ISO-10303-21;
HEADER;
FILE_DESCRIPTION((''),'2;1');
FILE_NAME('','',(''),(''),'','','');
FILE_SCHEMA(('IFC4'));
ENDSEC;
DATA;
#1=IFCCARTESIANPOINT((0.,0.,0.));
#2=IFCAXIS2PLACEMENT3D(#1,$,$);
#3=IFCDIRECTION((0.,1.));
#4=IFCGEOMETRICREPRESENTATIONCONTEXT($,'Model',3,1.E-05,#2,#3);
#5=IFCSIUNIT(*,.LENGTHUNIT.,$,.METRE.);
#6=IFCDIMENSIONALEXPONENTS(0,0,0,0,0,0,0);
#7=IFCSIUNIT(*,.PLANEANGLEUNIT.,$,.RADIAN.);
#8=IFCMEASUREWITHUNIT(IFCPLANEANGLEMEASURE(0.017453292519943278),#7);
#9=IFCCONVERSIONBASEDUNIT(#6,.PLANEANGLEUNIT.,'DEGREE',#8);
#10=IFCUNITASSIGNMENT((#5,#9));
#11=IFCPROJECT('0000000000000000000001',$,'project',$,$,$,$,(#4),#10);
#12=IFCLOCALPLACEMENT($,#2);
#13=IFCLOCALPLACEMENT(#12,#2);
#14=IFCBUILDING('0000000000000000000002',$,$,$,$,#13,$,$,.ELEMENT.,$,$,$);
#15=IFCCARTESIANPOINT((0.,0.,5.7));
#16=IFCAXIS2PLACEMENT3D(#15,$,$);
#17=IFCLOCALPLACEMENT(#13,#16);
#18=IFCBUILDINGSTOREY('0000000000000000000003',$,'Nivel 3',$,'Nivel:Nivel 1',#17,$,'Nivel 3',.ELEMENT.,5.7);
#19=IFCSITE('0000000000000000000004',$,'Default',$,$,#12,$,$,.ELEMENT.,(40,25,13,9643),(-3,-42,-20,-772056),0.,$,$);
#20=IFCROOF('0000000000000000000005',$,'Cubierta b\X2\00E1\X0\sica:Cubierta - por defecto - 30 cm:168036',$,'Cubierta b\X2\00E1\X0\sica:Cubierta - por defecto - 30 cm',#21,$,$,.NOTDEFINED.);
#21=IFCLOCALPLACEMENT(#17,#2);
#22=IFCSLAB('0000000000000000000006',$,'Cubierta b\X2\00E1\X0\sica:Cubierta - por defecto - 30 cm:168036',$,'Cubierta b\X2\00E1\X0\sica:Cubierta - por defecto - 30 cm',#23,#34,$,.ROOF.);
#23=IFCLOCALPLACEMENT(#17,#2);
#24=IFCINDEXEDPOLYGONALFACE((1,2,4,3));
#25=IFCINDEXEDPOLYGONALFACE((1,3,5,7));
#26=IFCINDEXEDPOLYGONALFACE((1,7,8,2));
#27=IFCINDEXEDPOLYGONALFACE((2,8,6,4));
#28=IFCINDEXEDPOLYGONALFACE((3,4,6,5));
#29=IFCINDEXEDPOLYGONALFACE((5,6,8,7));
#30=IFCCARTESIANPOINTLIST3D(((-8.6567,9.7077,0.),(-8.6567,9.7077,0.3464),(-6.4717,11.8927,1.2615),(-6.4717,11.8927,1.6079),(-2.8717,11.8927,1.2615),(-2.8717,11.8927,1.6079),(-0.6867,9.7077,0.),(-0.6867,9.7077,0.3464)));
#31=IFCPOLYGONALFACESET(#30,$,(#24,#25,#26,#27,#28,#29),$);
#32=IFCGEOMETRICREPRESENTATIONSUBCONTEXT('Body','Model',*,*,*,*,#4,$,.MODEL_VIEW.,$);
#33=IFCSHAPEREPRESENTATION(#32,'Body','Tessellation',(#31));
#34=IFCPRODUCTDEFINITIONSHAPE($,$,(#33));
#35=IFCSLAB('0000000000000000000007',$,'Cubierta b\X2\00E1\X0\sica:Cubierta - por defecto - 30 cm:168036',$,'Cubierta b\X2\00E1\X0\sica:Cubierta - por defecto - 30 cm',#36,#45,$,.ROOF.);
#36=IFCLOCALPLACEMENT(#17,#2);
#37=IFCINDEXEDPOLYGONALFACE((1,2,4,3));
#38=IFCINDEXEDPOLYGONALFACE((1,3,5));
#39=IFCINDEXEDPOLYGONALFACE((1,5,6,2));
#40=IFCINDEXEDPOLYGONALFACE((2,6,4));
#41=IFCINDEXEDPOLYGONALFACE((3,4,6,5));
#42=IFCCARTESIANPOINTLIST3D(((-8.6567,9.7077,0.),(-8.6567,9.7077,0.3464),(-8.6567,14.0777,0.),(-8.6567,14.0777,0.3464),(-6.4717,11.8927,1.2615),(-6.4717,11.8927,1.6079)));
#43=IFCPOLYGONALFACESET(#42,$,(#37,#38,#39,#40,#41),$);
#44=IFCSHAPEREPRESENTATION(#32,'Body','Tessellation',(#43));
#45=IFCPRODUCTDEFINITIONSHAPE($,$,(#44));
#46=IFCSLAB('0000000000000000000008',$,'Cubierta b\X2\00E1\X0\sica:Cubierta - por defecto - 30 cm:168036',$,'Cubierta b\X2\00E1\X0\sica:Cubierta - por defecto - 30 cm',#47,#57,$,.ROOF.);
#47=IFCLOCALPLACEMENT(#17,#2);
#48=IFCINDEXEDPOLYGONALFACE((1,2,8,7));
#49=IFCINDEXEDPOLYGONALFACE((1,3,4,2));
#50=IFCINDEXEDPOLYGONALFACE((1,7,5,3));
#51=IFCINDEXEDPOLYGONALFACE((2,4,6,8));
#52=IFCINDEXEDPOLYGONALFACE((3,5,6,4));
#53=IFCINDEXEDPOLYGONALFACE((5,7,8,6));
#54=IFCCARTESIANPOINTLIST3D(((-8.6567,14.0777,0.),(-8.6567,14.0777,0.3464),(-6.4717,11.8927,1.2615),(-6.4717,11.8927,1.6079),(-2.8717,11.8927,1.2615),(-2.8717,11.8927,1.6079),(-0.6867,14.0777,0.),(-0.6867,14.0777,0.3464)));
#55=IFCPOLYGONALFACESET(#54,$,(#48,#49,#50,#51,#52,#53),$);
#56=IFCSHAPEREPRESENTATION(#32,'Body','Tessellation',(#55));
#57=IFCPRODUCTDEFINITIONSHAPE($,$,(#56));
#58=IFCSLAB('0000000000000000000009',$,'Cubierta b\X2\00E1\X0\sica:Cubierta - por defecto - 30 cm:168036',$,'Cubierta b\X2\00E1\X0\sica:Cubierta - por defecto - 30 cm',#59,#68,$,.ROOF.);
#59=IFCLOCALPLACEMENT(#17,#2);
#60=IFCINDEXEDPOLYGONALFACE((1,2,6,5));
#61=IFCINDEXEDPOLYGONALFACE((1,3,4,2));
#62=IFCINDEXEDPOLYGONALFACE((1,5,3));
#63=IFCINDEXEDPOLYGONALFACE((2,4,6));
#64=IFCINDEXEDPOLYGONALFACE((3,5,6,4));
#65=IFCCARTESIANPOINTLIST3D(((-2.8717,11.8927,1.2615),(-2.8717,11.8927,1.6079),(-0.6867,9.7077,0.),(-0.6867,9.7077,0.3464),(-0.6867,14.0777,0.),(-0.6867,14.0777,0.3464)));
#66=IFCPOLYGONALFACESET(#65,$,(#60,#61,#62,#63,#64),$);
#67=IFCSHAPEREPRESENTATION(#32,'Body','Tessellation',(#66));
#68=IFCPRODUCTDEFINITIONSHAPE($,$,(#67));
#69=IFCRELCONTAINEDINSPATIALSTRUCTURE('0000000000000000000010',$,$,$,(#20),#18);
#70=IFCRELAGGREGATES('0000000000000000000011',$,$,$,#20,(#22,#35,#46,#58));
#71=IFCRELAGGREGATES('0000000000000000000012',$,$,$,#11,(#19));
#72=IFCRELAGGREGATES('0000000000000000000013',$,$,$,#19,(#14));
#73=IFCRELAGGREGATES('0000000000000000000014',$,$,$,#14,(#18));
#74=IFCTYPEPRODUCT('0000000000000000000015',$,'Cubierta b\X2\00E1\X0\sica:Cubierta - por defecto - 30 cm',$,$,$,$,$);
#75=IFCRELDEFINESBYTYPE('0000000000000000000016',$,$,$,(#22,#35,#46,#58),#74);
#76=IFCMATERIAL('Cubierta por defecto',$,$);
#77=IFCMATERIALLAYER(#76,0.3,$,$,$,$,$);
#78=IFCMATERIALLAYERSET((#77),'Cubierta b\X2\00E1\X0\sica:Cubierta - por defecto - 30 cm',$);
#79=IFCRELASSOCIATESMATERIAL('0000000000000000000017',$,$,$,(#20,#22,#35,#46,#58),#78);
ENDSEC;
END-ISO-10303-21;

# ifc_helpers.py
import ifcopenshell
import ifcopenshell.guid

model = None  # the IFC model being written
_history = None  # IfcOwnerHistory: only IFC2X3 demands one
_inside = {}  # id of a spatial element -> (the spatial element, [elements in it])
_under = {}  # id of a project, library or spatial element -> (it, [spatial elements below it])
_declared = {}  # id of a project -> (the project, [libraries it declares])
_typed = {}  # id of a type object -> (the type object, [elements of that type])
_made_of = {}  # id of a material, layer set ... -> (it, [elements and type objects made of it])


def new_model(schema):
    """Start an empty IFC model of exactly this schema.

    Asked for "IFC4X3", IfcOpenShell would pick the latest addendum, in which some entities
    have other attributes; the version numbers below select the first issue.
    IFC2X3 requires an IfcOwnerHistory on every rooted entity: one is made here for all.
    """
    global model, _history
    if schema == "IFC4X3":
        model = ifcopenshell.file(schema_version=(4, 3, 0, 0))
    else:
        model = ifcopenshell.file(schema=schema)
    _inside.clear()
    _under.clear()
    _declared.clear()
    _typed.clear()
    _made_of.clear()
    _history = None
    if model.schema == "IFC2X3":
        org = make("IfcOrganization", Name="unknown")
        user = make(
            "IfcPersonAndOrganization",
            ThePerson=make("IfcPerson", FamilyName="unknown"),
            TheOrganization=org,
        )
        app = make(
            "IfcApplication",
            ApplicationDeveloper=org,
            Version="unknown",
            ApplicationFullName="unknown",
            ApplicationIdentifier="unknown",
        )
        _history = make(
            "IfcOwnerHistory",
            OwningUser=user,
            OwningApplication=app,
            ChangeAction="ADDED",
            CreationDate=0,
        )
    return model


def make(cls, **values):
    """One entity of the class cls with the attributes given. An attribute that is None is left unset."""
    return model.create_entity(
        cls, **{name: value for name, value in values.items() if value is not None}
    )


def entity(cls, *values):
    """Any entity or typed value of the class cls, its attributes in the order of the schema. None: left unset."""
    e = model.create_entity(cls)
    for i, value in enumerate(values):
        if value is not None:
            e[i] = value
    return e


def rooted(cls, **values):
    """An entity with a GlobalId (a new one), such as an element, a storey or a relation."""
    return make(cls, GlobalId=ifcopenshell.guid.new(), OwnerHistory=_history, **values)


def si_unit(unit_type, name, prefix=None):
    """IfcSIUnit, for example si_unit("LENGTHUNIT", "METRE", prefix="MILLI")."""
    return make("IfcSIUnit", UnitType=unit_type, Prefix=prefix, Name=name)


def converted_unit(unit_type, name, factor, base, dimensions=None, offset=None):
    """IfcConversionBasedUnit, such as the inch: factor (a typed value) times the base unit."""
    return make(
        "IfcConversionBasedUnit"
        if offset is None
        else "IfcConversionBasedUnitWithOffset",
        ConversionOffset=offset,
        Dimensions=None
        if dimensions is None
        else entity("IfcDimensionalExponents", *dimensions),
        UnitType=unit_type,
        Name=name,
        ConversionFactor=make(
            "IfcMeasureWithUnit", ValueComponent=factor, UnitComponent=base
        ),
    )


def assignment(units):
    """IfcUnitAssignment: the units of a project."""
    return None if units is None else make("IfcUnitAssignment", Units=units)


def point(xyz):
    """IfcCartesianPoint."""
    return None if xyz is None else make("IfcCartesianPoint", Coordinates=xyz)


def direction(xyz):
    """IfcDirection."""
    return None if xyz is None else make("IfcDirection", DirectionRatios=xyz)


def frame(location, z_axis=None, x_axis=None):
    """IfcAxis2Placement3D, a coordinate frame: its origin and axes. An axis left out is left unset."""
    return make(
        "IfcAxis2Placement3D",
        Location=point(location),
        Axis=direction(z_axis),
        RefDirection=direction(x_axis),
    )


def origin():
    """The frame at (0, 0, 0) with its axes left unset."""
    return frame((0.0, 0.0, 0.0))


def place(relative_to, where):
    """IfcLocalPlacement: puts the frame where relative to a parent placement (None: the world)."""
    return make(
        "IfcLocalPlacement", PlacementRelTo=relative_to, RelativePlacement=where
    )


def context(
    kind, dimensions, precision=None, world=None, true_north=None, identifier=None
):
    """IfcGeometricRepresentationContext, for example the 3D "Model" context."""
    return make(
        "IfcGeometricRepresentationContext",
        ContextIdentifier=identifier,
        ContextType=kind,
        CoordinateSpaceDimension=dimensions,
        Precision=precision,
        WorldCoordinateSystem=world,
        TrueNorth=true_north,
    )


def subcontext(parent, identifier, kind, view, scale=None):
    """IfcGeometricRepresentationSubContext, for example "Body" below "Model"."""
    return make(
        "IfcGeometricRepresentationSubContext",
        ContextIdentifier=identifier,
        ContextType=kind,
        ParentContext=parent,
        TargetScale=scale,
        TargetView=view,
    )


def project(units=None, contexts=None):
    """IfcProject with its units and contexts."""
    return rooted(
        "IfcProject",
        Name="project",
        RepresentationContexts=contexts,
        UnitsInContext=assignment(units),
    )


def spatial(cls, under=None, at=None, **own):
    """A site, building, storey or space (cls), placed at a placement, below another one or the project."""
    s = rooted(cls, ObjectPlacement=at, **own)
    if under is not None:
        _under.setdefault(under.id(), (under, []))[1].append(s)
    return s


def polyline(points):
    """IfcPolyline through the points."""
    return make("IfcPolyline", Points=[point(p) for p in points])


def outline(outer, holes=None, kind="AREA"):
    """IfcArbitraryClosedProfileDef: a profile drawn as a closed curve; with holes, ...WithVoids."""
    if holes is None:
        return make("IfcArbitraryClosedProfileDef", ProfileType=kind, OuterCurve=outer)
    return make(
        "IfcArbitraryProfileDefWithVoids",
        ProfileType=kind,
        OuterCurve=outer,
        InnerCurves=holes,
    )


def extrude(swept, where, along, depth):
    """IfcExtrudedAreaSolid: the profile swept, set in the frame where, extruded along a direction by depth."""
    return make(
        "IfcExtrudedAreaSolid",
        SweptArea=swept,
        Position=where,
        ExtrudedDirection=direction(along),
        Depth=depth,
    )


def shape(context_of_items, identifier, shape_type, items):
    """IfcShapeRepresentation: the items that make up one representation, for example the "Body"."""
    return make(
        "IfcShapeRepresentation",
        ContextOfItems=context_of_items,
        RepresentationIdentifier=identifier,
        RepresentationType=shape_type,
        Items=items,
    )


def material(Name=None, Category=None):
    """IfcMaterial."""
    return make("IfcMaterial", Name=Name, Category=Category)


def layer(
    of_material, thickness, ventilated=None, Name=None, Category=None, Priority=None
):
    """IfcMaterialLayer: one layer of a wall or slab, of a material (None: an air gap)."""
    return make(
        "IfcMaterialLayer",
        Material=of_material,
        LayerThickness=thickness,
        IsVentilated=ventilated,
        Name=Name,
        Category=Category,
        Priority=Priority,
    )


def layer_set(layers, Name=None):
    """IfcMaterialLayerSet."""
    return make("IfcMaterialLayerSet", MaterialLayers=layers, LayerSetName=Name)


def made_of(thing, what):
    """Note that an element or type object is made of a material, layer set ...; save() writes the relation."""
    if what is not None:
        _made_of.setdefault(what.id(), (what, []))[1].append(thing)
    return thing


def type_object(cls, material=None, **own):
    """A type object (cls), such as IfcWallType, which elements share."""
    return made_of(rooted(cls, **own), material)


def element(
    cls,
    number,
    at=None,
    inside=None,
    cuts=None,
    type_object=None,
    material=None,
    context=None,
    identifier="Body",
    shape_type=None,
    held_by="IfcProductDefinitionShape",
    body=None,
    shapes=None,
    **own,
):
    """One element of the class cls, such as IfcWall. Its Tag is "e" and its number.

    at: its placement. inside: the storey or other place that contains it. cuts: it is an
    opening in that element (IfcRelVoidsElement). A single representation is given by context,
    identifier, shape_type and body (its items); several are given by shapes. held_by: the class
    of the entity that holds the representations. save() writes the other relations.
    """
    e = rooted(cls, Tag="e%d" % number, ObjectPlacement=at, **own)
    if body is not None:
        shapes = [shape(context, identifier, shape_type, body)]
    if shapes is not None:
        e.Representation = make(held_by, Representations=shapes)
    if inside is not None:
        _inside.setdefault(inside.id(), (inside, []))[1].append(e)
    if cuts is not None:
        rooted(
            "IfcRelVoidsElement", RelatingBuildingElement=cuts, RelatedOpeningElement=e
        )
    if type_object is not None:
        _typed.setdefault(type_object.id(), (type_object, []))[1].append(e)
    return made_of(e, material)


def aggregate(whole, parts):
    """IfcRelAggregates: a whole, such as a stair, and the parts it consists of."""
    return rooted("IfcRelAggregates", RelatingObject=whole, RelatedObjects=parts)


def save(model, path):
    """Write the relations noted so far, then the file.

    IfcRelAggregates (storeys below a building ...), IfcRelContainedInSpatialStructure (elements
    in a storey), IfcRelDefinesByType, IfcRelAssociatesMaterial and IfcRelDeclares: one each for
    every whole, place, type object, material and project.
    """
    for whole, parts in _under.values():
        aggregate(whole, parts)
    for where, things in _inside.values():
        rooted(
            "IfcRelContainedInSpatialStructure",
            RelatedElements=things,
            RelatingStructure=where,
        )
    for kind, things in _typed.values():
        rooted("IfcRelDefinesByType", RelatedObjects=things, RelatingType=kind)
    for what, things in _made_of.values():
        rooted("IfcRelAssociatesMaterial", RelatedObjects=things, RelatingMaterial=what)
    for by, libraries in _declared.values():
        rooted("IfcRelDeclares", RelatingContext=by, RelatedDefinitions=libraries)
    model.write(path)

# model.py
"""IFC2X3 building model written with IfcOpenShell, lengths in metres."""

from ifc_helpers import new_model, entity, si_unit, converted_unit, direction, frame, origin, place, context, subcontext, project, spatial, polyline, outline, extrude, material, layer, layer_set, type_object, element, aggregate, save


model = new_model("IFC2X3")

# Units and contexts
model_context = context("Model", 3, precision=1e-05, world=origin(), true_north=direction((0.0, 1.0)))
body_context = subcontext(model_context, "Body", "Model", "MODEL_VIEW")
ifc_project = project(units=[si_unit("LENGTHUNIT", "METRE"), converted_unit("PLANEANGLEUNIT", "DEGREE", entity("IfcPlaneAngleMeasure", 0.017453292519943278), si_unit("PLANEANGLEUNIT", "RADIAN"), dimensions=[0, 0, 0, 0, 0, 0, 0])], contexts=[model_context])

# Site, building, storey
site_placement = place(None, origin())
site = spatial("IfcSite", under=ifc_project, at=site_placement, Name="Default", CompositionType="ELEMENT", RefLatitude=(40, 25, 13, 9643), RefLongitude=(-3, -42, -20, -772056), RefElevation=0.0)
building_placement = place(site_placement, origin())
building = spatial("IfcBuilding", under=site, at=building_placement, CompositionType="ELEMENT")
storey_placement = place(building_placement, frame((0.0, 0.0, 5.7)))
storey = spatial("IfcBuildingStorey", under=building, at=storey_placement, Name="Nivel 3", ObjectType="Nivel:Nivel 1", LongName="Nivel 3", CompositionType="ELEMENT", Elevation=5.7)

# Roof, slabs
ifc_material = material(Name="Cubierta por defecto")
ifc_layer = layer(ifc_material, 0.3)
ifc_layer_set = layer_set([ifc_layer], Name="Cubierta básica:Cubierta - por defecto - 30 cm")
roof_placement = place(storey_placement, frame((-8.6567, 9.7077, 0.0)))
roof = element("IfcRoof", 1, at=roof_placement, inside=storey, material=ifc_layer_set, Name="Cubierta básica:Cubierta - por defecto - 30 cm:168036", ObjectType="Cubierta básica:Cubierta - por defecto - 30 cm", ShapeType="NOTDEFINED")
type_product = type_object("IfcTypeProduct", Name="Cubierta básica:Cubierta - por defecto - 30 cm")
slab_1_placement = place(roof_placement, origin())
slab_1 = element("IfcSlab", 2, at=slab_1_placement, type_object=type_product, material=ifc_layer_set, Name="Cubierta básica:Cubierta - por defecto - 30 cm:168036", ObjectType="Cubierta básica:Cubierta - por defecto - 30 cm", PredefinedType="ROOF", context=body_context, shape_type="SweptSolid", body=[
    extrude(outline(polyline([(1.8, 1.2615), (-1.8, 1.2615), (-3.985, -1.2615), (3.985, -1.2615), (1.8, 1.2615)])), frame((3.985, 1.0925, 0.6308), z_axis=(0.0, -0.5, 0.866025), x_axis=(1.0, 0.0, 0.0)), (0.0, 0.5, 0.866025), 0.3464),
])
slab_2_placement = place(roof_placement, origin())
slab_2 = element("IfcSlab", 3, at=slab_2_placement, type_object=type_product, material=ifc_layer_set, Name="Cubierta básica:Cubierta - por defecto - 30 cm:168036", ObjectType="Cubierta básica:Cubierta - por defecto - 30 cm", PredefinedType="ROOF", context=body_context, shape_type="SweptSolid", body=[
    extrude(outline(polyline([(-1.2615, 2.185), (-1.2615, -2.185), (1.2615, 0.0), (-1.2615, 2.185)])), frame((1.0925, 2.185, 0.6308), z_axis=(-0.5, 0.0, 0.866025), x_axis=(0.866025, 0.0, 0.5)), (0.5, 0.0, 0.866025), 0.3464),
])
slab_3_placement = place(roof_placement, origin())
slab_3 = element("IfcSlab", 4, at=slab_3_placement, type_object=type_product, material=ifc_layer_set, Name="Cubierta básica:Cubierta - por defecto - 30 cm:168036", ObjectType="Cubierta básica:Cubierta - por defecto - 30 cm", PredefinedType="ROOF", context=body_context, shape_type="SweptSolid", body=[
    extrude(outline(polyline([(3.985, 1.2615), (-3.985, 1.2615), (-1.8, -1.2615), (1.8, -1.2615), (3.985, 1.2615)])), frame((3.985, 3.2775, 0.6308), z_axis=(0.0, 0.5, 0.866025), x_axis=(1.0, 0.0, 0.0)), (0.0, -0.5, 0.866025), 0.3464),
])
slab_4_placement = place(roof_placement, origin())
slab_4 = element("IfcSlab", 5, at=slab_4_placement, type_object=type_product, material=ifc_layer_set, Name="Cubierta básica:Cubierta - por defecto - 30 cm:168036", ObjectType="Cubierta básica:Cubierta - por defecto - 30 cm", PredefinedType="ROOF", context=body_context, shape_type="SweptSolid", body=[
    extrude(outline(polyline([(1.2615, -2.185), (1.2615, 2.185), (-1.2615, 0.0), (1.2615, -2.185)])), frame((6.8775, 2.185, 0.6308), z_axis=(0.5, 0.0, 0.866025), x_axis=(0.866025, 0.0, -0.5)), (-0.5, 0.0, 0.866025), 0.3464),
])
aggregate(roof, [slab_1, slab_2, slab_3, slab_4])

save(model, "model.ifc")
